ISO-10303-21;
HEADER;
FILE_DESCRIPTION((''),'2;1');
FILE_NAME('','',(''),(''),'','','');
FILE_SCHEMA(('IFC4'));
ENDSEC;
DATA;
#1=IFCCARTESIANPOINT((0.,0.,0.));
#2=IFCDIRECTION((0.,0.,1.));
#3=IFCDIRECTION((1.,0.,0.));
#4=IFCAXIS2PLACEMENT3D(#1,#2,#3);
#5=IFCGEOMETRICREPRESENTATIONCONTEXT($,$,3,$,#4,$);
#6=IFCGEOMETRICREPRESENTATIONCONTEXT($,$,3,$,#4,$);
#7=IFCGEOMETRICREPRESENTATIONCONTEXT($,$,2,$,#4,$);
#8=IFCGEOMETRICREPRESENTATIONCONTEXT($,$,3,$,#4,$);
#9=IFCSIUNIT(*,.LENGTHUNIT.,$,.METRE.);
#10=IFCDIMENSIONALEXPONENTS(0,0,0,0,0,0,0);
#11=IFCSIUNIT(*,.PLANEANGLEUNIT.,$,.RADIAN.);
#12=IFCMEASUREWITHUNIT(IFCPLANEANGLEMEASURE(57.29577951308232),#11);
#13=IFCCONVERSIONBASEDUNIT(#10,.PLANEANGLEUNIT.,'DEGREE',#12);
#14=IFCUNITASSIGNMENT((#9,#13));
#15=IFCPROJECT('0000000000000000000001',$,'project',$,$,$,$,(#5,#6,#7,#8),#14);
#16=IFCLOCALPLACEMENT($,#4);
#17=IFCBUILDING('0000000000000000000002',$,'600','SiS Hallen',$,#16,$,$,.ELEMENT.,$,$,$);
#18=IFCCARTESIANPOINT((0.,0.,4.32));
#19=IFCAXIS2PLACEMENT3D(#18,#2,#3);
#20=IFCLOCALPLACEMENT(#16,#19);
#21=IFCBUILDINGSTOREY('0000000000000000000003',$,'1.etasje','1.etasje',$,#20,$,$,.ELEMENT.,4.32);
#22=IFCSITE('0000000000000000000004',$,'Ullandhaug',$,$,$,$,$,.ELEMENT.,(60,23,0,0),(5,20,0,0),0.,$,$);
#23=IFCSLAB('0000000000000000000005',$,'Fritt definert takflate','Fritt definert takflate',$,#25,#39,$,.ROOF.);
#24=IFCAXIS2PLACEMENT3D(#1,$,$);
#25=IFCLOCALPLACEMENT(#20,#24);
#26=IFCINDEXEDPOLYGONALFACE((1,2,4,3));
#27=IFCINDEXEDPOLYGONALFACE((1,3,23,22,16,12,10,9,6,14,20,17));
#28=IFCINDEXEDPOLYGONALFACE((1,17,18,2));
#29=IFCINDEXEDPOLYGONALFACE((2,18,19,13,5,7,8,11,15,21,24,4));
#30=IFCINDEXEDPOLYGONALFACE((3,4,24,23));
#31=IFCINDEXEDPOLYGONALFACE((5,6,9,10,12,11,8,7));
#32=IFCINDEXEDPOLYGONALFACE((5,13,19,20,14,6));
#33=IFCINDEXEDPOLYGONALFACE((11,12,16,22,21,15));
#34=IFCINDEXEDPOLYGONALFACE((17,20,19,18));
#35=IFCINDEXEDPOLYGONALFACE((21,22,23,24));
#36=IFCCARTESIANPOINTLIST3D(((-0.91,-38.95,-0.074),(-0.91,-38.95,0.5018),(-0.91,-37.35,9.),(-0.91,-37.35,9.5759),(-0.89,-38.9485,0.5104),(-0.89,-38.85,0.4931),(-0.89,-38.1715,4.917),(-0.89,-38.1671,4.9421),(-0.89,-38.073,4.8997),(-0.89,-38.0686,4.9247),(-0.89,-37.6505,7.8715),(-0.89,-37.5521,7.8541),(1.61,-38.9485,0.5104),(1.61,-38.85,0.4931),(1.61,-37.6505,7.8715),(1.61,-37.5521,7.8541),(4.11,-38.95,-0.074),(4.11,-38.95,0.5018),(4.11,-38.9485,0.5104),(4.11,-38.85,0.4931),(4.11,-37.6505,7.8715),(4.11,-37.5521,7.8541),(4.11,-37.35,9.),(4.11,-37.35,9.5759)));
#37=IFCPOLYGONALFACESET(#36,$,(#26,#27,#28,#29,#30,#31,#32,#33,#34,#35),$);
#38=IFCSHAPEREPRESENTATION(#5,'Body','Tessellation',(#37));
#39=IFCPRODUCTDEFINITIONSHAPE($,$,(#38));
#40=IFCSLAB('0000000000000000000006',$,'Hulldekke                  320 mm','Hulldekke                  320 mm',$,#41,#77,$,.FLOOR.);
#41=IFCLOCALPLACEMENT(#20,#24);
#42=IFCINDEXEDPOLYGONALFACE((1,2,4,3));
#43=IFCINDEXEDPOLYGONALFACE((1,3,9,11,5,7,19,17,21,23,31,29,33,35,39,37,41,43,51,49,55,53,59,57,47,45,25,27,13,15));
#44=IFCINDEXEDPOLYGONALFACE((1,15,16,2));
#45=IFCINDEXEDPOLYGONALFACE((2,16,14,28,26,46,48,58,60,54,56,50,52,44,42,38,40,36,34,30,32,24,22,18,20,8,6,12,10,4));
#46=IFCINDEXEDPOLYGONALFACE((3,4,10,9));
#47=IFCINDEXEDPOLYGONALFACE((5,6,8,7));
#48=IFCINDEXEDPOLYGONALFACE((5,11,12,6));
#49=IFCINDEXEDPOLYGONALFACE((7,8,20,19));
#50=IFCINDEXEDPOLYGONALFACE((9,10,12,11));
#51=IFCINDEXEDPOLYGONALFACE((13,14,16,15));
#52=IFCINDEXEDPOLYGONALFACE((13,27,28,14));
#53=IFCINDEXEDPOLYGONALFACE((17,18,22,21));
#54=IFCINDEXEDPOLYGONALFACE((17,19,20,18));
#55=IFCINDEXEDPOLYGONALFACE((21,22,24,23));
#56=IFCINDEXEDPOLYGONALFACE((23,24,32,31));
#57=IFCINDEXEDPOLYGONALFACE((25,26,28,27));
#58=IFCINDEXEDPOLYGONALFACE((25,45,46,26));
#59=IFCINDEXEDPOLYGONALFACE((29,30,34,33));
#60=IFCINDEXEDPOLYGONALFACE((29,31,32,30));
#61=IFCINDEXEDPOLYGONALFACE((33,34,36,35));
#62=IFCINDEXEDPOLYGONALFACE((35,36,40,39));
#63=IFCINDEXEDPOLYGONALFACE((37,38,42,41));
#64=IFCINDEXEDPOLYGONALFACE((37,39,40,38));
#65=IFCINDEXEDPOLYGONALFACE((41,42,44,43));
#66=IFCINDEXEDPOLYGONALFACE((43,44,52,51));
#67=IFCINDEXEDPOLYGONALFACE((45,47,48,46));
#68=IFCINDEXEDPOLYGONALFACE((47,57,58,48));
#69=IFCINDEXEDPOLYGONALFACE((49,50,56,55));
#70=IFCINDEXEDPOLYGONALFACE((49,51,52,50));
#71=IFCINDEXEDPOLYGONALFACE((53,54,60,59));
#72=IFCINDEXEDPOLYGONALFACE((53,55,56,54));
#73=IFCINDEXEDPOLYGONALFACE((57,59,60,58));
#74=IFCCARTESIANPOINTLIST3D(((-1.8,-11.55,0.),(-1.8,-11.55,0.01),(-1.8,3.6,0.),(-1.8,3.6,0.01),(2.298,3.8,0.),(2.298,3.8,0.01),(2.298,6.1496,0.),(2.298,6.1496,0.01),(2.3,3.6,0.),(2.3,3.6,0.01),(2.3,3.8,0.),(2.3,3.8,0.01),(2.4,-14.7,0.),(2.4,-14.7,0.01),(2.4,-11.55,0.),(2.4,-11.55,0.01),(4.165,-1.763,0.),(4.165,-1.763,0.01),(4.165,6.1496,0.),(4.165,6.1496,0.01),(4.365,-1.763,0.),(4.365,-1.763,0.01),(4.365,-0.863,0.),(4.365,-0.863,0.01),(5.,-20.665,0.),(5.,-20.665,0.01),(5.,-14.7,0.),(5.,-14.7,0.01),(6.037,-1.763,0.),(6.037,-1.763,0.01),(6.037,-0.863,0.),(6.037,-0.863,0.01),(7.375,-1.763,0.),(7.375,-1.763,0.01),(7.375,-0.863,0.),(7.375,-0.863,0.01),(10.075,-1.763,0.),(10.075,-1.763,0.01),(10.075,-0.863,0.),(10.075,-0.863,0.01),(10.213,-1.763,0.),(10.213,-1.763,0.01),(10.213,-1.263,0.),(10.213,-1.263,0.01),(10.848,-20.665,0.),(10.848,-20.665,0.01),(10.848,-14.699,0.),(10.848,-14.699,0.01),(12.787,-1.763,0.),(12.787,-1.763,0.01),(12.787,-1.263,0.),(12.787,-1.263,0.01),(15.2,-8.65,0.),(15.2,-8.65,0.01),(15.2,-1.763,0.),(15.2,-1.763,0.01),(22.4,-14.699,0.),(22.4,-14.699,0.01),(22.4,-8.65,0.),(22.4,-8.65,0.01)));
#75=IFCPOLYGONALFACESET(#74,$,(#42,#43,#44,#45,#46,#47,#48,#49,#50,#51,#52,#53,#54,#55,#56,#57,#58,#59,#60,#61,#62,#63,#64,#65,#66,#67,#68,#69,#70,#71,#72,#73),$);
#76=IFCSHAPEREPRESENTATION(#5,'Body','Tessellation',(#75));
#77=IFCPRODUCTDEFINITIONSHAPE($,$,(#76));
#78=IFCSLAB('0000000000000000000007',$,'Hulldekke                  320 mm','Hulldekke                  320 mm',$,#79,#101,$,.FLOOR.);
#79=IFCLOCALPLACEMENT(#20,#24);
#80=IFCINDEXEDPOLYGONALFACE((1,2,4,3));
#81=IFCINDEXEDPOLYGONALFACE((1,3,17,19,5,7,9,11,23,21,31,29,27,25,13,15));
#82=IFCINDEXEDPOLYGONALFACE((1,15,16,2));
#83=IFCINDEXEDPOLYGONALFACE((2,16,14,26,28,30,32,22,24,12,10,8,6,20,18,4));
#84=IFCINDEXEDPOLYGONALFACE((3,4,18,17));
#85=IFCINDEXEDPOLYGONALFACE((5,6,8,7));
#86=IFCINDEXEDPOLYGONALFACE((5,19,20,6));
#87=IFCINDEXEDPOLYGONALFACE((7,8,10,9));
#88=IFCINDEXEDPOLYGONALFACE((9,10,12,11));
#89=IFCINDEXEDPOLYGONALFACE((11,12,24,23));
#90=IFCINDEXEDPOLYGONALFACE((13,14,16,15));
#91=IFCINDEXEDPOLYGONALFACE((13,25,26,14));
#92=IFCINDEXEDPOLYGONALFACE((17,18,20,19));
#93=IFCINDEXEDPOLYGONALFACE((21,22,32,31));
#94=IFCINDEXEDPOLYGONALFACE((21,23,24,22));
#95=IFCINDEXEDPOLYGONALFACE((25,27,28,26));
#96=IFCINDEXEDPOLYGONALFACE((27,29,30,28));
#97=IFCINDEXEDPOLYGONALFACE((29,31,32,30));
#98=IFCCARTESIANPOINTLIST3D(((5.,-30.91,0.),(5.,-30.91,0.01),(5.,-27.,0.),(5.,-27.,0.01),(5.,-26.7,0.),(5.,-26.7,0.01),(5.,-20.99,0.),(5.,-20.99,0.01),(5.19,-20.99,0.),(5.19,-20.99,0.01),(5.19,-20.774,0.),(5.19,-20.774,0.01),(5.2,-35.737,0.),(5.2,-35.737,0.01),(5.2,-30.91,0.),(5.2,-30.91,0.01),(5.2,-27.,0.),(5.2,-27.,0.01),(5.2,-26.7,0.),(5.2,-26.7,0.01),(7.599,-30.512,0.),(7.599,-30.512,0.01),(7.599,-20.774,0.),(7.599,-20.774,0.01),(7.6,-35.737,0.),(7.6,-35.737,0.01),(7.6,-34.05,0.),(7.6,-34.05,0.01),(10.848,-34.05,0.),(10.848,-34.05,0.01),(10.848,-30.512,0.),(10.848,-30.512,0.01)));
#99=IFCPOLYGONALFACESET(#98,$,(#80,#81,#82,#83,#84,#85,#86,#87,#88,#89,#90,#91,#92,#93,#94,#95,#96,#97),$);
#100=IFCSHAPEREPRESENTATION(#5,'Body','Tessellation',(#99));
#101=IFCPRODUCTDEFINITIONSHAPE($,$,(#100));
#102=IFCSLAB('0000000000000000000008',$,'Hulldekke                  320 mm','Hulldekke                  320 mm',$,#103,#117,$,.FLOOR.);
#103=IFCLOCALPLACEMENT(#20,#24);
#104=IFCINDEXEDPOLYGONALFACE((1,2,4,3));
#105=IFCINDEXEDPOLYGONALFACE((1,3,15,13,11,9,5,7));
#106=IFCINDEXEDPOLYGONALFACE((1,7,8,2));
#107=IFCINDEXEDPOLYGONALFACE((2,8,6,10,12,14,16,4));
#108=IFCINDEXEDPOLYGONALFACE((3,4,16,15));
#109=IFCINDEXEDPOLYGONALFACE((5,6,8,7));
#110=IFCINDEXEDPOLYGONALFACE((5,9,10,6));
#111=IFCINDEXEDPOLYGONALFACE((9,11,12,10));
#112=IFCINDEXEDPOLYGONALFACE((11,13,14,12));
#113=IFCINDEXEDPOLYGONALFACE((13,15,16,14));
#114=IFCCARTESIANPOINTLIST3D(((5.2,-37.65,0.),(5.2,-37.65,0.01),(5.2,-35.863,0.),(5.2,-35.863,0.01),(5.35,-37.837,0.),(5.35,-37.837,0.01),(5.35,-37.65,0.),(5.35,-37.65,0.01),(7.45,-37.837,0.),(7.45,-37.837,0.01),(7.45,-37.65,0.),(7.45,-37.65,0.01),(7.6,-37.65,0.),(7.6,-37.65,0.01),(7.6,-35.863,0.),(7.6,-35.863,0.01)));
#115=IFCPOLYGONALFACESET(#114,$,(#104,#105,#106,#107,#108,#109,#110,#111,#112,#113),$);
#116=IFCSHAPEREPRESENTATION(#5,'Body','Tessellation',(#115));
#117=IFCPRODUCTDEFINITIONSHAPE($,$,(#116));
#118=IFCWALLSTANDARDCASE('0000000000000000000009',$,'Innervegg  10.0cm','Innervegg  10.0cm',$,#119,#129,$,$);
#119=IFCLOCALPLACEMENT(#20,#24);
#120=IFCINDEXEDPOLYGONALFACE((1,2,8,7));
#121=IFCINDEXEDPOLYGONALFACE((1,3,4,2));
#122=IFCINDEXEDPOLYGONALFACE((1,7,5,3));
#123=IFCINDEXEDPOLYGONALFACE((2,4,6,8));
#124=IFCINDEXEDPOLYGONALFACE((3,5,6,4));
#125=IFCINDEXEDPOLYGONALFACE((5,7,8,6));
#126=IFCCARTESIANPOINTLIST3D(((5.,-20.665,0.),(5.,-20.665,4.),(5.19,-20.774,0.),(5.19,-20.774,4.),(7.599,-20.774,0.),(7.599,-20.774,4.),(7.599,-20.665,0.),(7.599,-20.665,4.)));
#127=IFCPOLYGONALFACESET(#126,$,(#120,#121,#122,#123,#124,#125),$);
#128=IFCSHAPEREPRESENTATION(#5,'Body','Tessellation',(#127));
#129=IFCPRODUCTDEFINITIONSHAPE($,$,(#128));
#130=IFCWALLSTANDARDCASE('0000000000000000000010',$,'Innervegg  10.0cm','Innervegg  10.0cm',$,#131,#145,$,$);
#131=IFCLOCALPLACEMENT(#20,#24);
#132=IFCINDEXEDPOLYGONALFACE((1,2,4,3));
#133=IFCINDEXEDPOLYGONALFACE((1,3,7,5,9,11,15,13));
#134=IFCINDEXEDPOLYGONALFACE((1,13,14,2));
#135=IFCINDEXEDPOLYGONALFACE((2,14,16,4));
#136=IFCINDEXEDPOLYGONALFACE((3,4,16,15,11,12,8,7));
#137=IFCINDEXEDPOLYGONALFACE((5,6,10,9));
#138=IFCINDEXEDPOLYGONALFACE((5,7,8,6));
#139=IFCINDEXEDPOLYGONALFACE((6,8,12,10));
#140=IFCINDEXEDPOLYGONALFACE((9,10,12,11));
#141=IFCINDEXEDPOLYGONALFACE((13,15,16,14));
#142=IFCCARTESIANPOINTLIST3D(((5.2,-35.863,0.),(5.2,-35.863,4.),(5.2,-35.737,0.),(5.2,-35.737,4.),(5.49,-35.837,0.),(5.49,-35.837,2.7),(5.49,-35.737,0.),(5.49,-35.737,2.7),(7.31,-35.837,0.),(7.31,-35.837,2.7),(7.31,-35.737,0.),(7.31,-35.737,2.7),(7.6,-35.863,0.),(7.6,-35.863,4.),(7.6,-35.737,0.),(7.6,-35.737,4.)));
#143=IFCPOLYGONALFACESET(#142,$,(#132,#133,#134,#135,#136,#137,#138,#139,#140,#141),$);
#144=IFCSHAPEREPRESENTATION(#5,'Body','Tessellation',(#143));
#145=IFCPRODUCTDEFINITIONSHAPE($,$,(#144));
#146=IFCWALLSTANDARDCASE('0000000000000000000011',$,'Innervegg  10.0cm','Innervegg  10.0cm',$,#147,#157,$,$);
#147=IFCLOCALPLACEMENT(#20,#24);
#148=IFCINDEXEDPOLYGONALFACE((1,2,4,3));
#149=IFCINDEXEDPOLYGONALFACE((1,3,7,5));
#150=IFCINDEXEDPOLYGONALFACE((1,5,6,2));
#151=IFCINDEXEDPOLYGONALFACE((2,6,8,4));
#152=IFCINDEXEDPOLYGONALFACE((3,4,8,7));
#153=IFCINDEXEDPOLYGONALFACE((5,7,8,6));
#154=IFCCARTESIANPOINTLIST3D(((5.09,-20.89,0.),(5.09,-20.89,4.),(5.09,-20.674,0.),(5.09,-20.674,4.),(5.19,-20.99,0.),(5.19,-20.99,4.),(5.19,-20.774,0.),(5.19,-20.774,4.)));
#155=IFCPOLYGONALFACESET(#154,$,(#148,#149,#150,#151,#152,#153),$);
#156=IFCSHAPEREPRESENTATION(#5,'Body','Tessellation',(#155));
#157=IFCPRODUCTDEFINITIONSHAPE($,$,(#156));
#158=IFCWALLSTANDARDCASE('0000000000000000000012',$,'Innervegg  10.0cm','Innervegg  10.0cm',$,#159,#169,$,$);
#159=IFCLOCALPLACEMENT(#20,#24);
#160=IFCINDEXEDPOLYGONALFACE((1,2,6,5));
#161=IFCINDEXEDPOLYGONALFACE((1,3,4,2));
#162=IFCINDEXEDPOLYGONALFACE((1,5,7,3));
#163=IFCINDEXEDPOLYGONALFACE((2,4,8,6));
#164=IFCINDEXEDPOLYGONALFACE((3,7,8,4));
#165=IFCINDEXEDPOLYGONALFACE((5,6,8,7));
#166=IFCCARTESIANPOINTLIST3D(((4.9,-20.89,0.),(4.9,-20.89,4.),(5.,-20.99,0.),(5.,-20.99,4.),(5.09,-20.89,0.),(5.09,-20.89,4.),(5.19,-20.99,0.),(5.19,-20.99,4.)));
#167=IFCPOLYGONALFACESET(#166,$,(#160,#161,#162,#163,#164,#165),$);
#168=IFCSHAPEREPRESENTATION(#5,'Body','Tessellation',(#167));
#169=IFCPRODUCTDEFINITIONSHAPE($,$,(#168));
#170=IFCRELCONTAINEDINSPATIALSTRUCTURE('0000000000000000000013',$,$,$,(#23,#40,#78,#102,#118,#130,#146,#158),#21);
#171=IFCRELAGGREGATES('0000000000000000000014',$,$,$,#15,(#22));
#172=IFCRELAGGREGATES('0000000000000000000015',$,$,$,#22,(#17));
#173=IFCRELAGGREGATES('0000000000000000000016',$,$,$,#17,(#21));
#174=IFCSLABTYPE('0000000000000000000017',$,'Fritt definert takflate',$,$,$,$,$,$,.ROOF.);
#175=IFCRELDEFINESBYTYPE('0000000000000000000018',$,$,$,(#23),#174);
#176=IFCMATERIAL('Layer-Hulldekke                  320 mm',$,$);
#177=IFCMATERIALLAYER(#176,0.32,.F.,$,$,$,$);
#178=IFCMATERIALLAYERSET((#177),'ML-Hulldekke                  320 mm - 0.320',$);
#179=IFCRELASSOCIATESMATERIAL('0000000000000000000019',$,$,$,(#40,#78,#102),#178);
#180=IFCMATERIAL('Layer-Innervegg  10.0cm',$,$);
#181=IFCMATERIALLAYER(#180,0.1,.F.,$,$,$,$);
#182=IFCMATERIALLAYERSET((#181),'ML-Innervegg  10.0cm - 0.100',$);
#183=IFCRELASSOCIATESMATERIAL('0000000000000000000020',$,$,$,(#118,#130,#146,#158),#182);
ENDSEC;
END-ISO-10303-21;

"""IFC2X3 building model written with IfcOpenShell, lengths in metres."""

from ifc_helpers import new_model, entity, si_unit, converted_unit, frame, origin_with_axes, place, context, project, spatial, polyline, outline, extrude, material, layer, layer_set, layer_usage, type_object, element, save


model = new_model("IFC2X3")

# Units and contexts
context_of_model_1 = context(None, 3, world=origin_with_axes())
context_of_model_2 = context(None, 3, world=origin_with_axes())
context_of_model_3 = context(None, 2, world=origin_with_axes())
context_of_model_4 = context(None, 3, world=origin_with_axes())
ifc_project = project(units=[si_unit("LENGTHUNIT", "METRE"), converted_unit("PLANEANGLEUNIT", "DEGREE", entity("IfcPlaneAngleMeasure", 57.29577951308232), si_unit("PLANEANGLEUNIT", "RADIAN"), dimensions=[0, 0, 0, 0, 0, 0, 0])], contexts=[context_of_model_1, context_of_model_2, context_of_model_3, context_of_model_4])

# Site, building, storey
site = spatial("IfcSite", under=ifc_project, Name="Ullandhaug", CompositionType="ELEMENT", RefLatitude=(60, 23, 0, 0), RefLongitude=(5, 20, 0, 0), RefElevation=0.0)
building_placement = place(None, origin_with_axes())
building = spatial("IfcBuilding", under=site, at=building_placement, Name="600", Description="SiS Hallen", CompositionType="ELEMENT")
storey_placement = place(building_placement, frame((0.0, 0.0, 4.32), z_axis=(0.0, 0.0, 1.0), x_axis=(1.0, 0.0, 0.0)))
storey = spatial("IfcBuildingStorey", under=building, at=storey_placement, Name="1.etasje", Description="1.etasje", CompositionType="ELEMENT", Elevation=4.32)

# Slab, openings
slab_type = type_object("IfcSlabType", Name="Fritt definert takflate", PredefinedType="ROOF")
slab_1_placement = place(storey_placement, frame((4.11, -37.35, 9.0), z_axis=(0.0, -0.984808, 0.173648), x_axis=(-1.0, 0.0, 0.0)))
slab_1 = element("IfcSlab", 1, at=slab_1_placement, inside=storey, type_object=slab_type, Name="Fritt definert takflate", Description="Fritt definert takflate", PredefinedType="ROOF", context=context_of_model_1, shape_type="SweptSolid", body=[
    extrude(outline(polyline([(0.0, 0.0), (5.02, 0.0), (5.02, 9.214), (0.0, 9.214), (0.0, 0.0)])), origin_with_axes(), (0.0, -0.984808, 0.173648), 0.5759),
])
opening_1_placement = place(slab_1_placement, frame((0.0, 8.6382, 0.0), z_axis=(0.0, 0.0, 1.0), x_axis=(1.0, 0.0, 0.0)))
element("IfcOpeningElement", 2, at=opening_1_placement, cuts=slab_1, context=context_of_model_1, shape_type="SweptSolid", body=[
    extrude(outline(polyline([(0.0, 0.0), (2.5, 0.0), (2.5, 4.5), (0.0, 4.5), (0.0, 0.0)])), frame((0.0, 0.0, 0.0), z_axis=(0.0, 0.0, -1.0), x_axis=(1.0, 0.0, 0.0)), (0.0, 0.0, -1.0), 0.1),
])
opening_2_placement = place(slab_1_placement, frame((0.0, 4.1636, 0.0), z_axis=(0.0, 0.0, 1.0), x_axis=(1.0, 0.0, 0.0)))
element("IfcOpeningElement", 3, at=opening_2_placement, cuts=slab_1, context=context_of_model_1, shape_type="SweptSolid", body=[
    extrude(outline(polyline([(0.0, 0.0), (2.5, 0.0), (2.5, 3.0), (0.0, 3.0), (0.0, 0.0)])), frame((0.0, 0.0, 0.0), z_axis=(0.0, 0.0, -1.0), x_axis=(1.0, 0.0, 0.0)), (0.0, 0.0, -1.0), 0.1),
])
opening_3_placement = place(slab_1_placement, frame((2.5, 8.6382, 0.0), z_axis=(0.0, 0.0, 1.0), x_axis=(1.0, 0.0, 0.0)))
element("IfcOpeningElement", 4, at=opening_3_placement, cuts=slab_1, context=context_of_model_1, shape_type="SweptSolid", body=[
    extrude(outline(polyline([(0.0, 0.0), (2.5, 0.0), (2.5, 4.5), (0.0, 4.5), (0.0, 0.0)])), frame((0.0, 0.0, 0.0), z_axis=(0.0, 0.0, -1.0), x_axis=(1.0, 0.0, 0.0)), (0.0, 0.0, -1.0), 0.1),
])
opening_4_placement = place(slab_1_placement, frame((2.5, 4.1636, 0.0), z_axis=(0.0, 0.0, 1.0), x_axis=(1.0, 0.0, 0.0)))
element("IfcOpeningElement", 5, at=opening_4_placement, cuts=slab_1, context=context_of_model_1, shape_type="SweptSolid", body=[
    extrude(outline(polyline([(0.0, 0.0), (2.5, 0.0), (2.5, 3.0), (0.0, 3.0), (0.0, 0.0)])), frame((0.0, 0.0, 0.0), z_axis=(0.0, 0.0, -1.0), x_axis=(1.0, 0.0, 0.0)), (0.0, 0.0, -1.0), 0.1),
])

# Slabs
ifc_material_1 = material(Name="Layer-Hulldekke                  320 mm")
ifc_layer_1 = layer(ifc_material_1, 0.32, ventilated=False)
ifc_layer_set_1 = layer_set([ifc_layer_1], Name="ML-Hulldekke                  320 mm - 0.320")
ifc_layer_usage_1 = layer_usage(ifc_layer_set_1, "AXIS2", "POSITIVE", 0.0)
slab_2_placement = place(storey_placement, frame((5.0, -20.665, 0.0), z_axis=(0.0, 0.0, 1.0), x_axis=(1.0, 0.0, 0.0)))
element("IfcSlab", 6, at=slab_2_placement, inside=storey, material=ifc_layer_usage_1, Name="Hulldekke                  320 mm", Description="Hulldekke                  320 mm", PredefinedType="FLOOR", context=context_of_model_1, shape_type="SweptSolid", body=[
    extrude(outline(polyline([(0.0, 0.0), (5.848, 0.0), (5.848, 5.966), (17.4, 5.966), (17.4, 12.015), (10.2, 12.015), (10.2, 18.902), (7.787, 18.902), (7.787, 19.402), (5.213, 19.402), (5.213, 18.902), (5.075, 18.902), (5.075, 19.802), (2.375, 19.802), (2.375, 18.902), (1.037, 18.902), (1.037, 19.802), (-0.635, 19.802), (-0.635, 18.902), (-0.835, 18.902), (-0.835, 26.8146), (-2.702, 26.8146), (-2.702, 24.465), (-2.7, 24.465), (-2.7, 24.265), (-6.8, 24.265), (-6.8, 9.115), (-2.6, 9.115), (-2.6, 5.965), (0.0, 5.965), (0.0, 0.0)])), origin_with_axes(), (0.0, 0.0, 1.0), 0.01),
])
slab_3_placement = place(storey_placement, frame((5.2, -35.737, 0.0), z_axis=(0.0, 0.0, 1.0), x_axis=(1.0, 0.0, 0.0)))
element("IfcSlab", 7, at=slab_3_placement, inside=storey, material=ifc_layer_usage_1, Name="Hulldekke                  320 mm", Description="Hulldekke                  320 mm", PredefinedType="FLOOR", context=context_of_model_1, shape_type="SweptSolid", body=[
    extrude(outline(polyline([(0.0, 0.0), (2.4, 0.0), (2.4, 1.687), (5.648, 1.687), (5.648, 5.225), (2.399, 5.225), (2.399, 14.963), (-0.01, 14.963), (-0.01, 14.747), (-0.2, 14.747), (-0.2, 9.037), (0.0, 9.037), (0.0, 8.737), (-0.2, 8.737), (-0.2, 4.827), (0.0, 4.827), (0.0, 0.0)])), origin_with_axes(), (0.0, 0.0, 1.0), 0.01),
])
slab_4_placement = place(storey_placement, frame((5.35, -37.837, 0.0), z_axis=(0.0, 0.0, 1.0), x_axis=(1.0, 0.0, 0.0)))
element("IfcSlab", 8, at=slab_4_placement, inside=storey, material=ifc_layer_usage_1, Name="Hulldekke                  320 mm", Description="Hulldekke                  320 mm", PredefinedType="FLOOR", context=context_of_model_1, shape_type="SweptSolid", body=[
    extrude(outline(polyline([(0.0, 0.0), (2.1, 0.0), (2.1, 0.187), (2.25, 0.187), (2.25, 1.974), (-0.15, 1.974), (-0.15, 0.187), (0.0, 0.187), (0.0, 0.0)])), origin_with_axes(), (0.0, 0.0, 1.0), 0.01),
])

# Wall
ifc_material_2 = material(Name="Layer-Innervegg  10.0cm")
ifc_layer_2 = layer(ifc_material_2, 0.1, ventilated=False)
ifc_layer_set_2 = layer_set([ifc_layer_2], Name="ML-Innervegg  10.0cm - 0.100")
ifc_layer_usage_2 = layer_usage(ifc_layer_set_2, "AXIS2", "POSITIVE", 0.0)
wall_1_placement = place(storey_placement, frame((5.19, -20.774, 0.0), z_axis=(0.0, 0.0, 1.0), x_axis=(1.0, 0.0, 0.0)))
element("IfcWallStandardCase", 9, at=wall_1_placement, inside=storey, material=ifc_layer_usage_2, Name="Innervegg  10.0cm", Description="Innervegg  10.0cm", context=context_of_model_1, shape_type="SweptSolid", body=[
    extrude(outline(polyline([(0.0, 0.0), (2.409, 0.0), (2.409, 0.109), (-0.19, 0.109), (0.0, 0.0)])), origin_with_axes(), (0.0, 0.0, 1.0), 4.0),
])

# Wall, opening
wall_2_placement = place(storey_placement, frame((5.2, -35.863, 0.0), z_axis=(0.0, 0.0, 1.0), x_axis=(1.0, 0.0, 0.0)))
wall_2 = element("IfcWallStandardCase", 10, at=wall_2_placement, inside=storey, material=ifc_layer_usage_2, Name="Innervegg  10.0cm", Description="Innervegg  10.0cm", context=context_of_model_1, shape_type="SweptSolid", body=[
    extrude(outline(polyline([(0.0, 0.0), (2.4, 0.0), (2.4, 0.126), (0.0, 0.126), (0.0, 0.0)])), origin_with_axes(), (0.0, 0.0, 1.0), 4.0),
])
opening_5_placement = place(wall_2_placement, frame((0.29, 0.126, 0.0), z_axis=(0.0, 0.0, 1.0), x_axis=(1.0, 0.0, 0.0)))
element("IfcOpeningElement", 11, at=opening_5_placement, cuts=wall_2, context=context_of_model_1, shape_type="SweptSolid", body=[
    extrude(outline(polyline([(0.0, 0.0), (2.7, 0.0), (2.7, 1.82), (0.0, 1.82), (0.0, 0.0)])), frame((0.0, 0.0, 0.0), z_axis=(0.0, 1.0, 0.0), x_axis=(0.0, 0.0, 1.0)), (0.0, 0.0, -1.0), 0.1),
])

# Walls
wall_3_placement = place(storey_placement, frame((5.09, -20.674, 0.0), z_axis=(0.0, 0.0, 1.0), x_axis=(0.0, -1.0, 0.0)))
element("IfcWallStandardCase", 12, at=wall_3_placement, inside=storey, material=ifc_layer_usage_2, Name="Innervegg  10.0cm", Description="Innervegg  10.0cm", context=context_of_model_1, shape_type="SweptSolid", body=[
    extrude(outline(polyline([(0.0, 0.0), (0.216, 0.0), (0.316, 0.1), (0.1, 0.1), (0.0, 0.0)])), frame((0.0, 0.0, 0.0), z_axis=(0.0, 0.0, 1.0), x_axis=(1.0, 0.0, 0.0)), (0.0, 0.0, 1.0), 4.0),
])
wall_4_placement = place(storey_placement, frame((5.09, -20.89, 0.0), z_axis=(0.0, 0.0, 1.0), x_axis=(-1.0, 0.0, 0.0)))
element("IfcWallStandardCase", 13, at=wall_4_placement, inside=storey, material=ifc_layer_usage_2, Name="Innervegg  10.0cm", Description="Innervegg  10.0cm", context=context_of_model_1, shape_type="SweptSolid", body=[
    extrude(outline(polyline([(0.0, 0.0), (0.19, 0.0), (0.09, 0.1), (-0.1, 0.1), (0.0, 0.0)])), frame((0.0, 0.0, 0.0), z_axis=(0.0, 0.0, 1.0), x_axis=(1.0, 0.0, 0.0)), (0.0, 0.0, 1.0), 4.0),
])

save(model, "model.ifc")
